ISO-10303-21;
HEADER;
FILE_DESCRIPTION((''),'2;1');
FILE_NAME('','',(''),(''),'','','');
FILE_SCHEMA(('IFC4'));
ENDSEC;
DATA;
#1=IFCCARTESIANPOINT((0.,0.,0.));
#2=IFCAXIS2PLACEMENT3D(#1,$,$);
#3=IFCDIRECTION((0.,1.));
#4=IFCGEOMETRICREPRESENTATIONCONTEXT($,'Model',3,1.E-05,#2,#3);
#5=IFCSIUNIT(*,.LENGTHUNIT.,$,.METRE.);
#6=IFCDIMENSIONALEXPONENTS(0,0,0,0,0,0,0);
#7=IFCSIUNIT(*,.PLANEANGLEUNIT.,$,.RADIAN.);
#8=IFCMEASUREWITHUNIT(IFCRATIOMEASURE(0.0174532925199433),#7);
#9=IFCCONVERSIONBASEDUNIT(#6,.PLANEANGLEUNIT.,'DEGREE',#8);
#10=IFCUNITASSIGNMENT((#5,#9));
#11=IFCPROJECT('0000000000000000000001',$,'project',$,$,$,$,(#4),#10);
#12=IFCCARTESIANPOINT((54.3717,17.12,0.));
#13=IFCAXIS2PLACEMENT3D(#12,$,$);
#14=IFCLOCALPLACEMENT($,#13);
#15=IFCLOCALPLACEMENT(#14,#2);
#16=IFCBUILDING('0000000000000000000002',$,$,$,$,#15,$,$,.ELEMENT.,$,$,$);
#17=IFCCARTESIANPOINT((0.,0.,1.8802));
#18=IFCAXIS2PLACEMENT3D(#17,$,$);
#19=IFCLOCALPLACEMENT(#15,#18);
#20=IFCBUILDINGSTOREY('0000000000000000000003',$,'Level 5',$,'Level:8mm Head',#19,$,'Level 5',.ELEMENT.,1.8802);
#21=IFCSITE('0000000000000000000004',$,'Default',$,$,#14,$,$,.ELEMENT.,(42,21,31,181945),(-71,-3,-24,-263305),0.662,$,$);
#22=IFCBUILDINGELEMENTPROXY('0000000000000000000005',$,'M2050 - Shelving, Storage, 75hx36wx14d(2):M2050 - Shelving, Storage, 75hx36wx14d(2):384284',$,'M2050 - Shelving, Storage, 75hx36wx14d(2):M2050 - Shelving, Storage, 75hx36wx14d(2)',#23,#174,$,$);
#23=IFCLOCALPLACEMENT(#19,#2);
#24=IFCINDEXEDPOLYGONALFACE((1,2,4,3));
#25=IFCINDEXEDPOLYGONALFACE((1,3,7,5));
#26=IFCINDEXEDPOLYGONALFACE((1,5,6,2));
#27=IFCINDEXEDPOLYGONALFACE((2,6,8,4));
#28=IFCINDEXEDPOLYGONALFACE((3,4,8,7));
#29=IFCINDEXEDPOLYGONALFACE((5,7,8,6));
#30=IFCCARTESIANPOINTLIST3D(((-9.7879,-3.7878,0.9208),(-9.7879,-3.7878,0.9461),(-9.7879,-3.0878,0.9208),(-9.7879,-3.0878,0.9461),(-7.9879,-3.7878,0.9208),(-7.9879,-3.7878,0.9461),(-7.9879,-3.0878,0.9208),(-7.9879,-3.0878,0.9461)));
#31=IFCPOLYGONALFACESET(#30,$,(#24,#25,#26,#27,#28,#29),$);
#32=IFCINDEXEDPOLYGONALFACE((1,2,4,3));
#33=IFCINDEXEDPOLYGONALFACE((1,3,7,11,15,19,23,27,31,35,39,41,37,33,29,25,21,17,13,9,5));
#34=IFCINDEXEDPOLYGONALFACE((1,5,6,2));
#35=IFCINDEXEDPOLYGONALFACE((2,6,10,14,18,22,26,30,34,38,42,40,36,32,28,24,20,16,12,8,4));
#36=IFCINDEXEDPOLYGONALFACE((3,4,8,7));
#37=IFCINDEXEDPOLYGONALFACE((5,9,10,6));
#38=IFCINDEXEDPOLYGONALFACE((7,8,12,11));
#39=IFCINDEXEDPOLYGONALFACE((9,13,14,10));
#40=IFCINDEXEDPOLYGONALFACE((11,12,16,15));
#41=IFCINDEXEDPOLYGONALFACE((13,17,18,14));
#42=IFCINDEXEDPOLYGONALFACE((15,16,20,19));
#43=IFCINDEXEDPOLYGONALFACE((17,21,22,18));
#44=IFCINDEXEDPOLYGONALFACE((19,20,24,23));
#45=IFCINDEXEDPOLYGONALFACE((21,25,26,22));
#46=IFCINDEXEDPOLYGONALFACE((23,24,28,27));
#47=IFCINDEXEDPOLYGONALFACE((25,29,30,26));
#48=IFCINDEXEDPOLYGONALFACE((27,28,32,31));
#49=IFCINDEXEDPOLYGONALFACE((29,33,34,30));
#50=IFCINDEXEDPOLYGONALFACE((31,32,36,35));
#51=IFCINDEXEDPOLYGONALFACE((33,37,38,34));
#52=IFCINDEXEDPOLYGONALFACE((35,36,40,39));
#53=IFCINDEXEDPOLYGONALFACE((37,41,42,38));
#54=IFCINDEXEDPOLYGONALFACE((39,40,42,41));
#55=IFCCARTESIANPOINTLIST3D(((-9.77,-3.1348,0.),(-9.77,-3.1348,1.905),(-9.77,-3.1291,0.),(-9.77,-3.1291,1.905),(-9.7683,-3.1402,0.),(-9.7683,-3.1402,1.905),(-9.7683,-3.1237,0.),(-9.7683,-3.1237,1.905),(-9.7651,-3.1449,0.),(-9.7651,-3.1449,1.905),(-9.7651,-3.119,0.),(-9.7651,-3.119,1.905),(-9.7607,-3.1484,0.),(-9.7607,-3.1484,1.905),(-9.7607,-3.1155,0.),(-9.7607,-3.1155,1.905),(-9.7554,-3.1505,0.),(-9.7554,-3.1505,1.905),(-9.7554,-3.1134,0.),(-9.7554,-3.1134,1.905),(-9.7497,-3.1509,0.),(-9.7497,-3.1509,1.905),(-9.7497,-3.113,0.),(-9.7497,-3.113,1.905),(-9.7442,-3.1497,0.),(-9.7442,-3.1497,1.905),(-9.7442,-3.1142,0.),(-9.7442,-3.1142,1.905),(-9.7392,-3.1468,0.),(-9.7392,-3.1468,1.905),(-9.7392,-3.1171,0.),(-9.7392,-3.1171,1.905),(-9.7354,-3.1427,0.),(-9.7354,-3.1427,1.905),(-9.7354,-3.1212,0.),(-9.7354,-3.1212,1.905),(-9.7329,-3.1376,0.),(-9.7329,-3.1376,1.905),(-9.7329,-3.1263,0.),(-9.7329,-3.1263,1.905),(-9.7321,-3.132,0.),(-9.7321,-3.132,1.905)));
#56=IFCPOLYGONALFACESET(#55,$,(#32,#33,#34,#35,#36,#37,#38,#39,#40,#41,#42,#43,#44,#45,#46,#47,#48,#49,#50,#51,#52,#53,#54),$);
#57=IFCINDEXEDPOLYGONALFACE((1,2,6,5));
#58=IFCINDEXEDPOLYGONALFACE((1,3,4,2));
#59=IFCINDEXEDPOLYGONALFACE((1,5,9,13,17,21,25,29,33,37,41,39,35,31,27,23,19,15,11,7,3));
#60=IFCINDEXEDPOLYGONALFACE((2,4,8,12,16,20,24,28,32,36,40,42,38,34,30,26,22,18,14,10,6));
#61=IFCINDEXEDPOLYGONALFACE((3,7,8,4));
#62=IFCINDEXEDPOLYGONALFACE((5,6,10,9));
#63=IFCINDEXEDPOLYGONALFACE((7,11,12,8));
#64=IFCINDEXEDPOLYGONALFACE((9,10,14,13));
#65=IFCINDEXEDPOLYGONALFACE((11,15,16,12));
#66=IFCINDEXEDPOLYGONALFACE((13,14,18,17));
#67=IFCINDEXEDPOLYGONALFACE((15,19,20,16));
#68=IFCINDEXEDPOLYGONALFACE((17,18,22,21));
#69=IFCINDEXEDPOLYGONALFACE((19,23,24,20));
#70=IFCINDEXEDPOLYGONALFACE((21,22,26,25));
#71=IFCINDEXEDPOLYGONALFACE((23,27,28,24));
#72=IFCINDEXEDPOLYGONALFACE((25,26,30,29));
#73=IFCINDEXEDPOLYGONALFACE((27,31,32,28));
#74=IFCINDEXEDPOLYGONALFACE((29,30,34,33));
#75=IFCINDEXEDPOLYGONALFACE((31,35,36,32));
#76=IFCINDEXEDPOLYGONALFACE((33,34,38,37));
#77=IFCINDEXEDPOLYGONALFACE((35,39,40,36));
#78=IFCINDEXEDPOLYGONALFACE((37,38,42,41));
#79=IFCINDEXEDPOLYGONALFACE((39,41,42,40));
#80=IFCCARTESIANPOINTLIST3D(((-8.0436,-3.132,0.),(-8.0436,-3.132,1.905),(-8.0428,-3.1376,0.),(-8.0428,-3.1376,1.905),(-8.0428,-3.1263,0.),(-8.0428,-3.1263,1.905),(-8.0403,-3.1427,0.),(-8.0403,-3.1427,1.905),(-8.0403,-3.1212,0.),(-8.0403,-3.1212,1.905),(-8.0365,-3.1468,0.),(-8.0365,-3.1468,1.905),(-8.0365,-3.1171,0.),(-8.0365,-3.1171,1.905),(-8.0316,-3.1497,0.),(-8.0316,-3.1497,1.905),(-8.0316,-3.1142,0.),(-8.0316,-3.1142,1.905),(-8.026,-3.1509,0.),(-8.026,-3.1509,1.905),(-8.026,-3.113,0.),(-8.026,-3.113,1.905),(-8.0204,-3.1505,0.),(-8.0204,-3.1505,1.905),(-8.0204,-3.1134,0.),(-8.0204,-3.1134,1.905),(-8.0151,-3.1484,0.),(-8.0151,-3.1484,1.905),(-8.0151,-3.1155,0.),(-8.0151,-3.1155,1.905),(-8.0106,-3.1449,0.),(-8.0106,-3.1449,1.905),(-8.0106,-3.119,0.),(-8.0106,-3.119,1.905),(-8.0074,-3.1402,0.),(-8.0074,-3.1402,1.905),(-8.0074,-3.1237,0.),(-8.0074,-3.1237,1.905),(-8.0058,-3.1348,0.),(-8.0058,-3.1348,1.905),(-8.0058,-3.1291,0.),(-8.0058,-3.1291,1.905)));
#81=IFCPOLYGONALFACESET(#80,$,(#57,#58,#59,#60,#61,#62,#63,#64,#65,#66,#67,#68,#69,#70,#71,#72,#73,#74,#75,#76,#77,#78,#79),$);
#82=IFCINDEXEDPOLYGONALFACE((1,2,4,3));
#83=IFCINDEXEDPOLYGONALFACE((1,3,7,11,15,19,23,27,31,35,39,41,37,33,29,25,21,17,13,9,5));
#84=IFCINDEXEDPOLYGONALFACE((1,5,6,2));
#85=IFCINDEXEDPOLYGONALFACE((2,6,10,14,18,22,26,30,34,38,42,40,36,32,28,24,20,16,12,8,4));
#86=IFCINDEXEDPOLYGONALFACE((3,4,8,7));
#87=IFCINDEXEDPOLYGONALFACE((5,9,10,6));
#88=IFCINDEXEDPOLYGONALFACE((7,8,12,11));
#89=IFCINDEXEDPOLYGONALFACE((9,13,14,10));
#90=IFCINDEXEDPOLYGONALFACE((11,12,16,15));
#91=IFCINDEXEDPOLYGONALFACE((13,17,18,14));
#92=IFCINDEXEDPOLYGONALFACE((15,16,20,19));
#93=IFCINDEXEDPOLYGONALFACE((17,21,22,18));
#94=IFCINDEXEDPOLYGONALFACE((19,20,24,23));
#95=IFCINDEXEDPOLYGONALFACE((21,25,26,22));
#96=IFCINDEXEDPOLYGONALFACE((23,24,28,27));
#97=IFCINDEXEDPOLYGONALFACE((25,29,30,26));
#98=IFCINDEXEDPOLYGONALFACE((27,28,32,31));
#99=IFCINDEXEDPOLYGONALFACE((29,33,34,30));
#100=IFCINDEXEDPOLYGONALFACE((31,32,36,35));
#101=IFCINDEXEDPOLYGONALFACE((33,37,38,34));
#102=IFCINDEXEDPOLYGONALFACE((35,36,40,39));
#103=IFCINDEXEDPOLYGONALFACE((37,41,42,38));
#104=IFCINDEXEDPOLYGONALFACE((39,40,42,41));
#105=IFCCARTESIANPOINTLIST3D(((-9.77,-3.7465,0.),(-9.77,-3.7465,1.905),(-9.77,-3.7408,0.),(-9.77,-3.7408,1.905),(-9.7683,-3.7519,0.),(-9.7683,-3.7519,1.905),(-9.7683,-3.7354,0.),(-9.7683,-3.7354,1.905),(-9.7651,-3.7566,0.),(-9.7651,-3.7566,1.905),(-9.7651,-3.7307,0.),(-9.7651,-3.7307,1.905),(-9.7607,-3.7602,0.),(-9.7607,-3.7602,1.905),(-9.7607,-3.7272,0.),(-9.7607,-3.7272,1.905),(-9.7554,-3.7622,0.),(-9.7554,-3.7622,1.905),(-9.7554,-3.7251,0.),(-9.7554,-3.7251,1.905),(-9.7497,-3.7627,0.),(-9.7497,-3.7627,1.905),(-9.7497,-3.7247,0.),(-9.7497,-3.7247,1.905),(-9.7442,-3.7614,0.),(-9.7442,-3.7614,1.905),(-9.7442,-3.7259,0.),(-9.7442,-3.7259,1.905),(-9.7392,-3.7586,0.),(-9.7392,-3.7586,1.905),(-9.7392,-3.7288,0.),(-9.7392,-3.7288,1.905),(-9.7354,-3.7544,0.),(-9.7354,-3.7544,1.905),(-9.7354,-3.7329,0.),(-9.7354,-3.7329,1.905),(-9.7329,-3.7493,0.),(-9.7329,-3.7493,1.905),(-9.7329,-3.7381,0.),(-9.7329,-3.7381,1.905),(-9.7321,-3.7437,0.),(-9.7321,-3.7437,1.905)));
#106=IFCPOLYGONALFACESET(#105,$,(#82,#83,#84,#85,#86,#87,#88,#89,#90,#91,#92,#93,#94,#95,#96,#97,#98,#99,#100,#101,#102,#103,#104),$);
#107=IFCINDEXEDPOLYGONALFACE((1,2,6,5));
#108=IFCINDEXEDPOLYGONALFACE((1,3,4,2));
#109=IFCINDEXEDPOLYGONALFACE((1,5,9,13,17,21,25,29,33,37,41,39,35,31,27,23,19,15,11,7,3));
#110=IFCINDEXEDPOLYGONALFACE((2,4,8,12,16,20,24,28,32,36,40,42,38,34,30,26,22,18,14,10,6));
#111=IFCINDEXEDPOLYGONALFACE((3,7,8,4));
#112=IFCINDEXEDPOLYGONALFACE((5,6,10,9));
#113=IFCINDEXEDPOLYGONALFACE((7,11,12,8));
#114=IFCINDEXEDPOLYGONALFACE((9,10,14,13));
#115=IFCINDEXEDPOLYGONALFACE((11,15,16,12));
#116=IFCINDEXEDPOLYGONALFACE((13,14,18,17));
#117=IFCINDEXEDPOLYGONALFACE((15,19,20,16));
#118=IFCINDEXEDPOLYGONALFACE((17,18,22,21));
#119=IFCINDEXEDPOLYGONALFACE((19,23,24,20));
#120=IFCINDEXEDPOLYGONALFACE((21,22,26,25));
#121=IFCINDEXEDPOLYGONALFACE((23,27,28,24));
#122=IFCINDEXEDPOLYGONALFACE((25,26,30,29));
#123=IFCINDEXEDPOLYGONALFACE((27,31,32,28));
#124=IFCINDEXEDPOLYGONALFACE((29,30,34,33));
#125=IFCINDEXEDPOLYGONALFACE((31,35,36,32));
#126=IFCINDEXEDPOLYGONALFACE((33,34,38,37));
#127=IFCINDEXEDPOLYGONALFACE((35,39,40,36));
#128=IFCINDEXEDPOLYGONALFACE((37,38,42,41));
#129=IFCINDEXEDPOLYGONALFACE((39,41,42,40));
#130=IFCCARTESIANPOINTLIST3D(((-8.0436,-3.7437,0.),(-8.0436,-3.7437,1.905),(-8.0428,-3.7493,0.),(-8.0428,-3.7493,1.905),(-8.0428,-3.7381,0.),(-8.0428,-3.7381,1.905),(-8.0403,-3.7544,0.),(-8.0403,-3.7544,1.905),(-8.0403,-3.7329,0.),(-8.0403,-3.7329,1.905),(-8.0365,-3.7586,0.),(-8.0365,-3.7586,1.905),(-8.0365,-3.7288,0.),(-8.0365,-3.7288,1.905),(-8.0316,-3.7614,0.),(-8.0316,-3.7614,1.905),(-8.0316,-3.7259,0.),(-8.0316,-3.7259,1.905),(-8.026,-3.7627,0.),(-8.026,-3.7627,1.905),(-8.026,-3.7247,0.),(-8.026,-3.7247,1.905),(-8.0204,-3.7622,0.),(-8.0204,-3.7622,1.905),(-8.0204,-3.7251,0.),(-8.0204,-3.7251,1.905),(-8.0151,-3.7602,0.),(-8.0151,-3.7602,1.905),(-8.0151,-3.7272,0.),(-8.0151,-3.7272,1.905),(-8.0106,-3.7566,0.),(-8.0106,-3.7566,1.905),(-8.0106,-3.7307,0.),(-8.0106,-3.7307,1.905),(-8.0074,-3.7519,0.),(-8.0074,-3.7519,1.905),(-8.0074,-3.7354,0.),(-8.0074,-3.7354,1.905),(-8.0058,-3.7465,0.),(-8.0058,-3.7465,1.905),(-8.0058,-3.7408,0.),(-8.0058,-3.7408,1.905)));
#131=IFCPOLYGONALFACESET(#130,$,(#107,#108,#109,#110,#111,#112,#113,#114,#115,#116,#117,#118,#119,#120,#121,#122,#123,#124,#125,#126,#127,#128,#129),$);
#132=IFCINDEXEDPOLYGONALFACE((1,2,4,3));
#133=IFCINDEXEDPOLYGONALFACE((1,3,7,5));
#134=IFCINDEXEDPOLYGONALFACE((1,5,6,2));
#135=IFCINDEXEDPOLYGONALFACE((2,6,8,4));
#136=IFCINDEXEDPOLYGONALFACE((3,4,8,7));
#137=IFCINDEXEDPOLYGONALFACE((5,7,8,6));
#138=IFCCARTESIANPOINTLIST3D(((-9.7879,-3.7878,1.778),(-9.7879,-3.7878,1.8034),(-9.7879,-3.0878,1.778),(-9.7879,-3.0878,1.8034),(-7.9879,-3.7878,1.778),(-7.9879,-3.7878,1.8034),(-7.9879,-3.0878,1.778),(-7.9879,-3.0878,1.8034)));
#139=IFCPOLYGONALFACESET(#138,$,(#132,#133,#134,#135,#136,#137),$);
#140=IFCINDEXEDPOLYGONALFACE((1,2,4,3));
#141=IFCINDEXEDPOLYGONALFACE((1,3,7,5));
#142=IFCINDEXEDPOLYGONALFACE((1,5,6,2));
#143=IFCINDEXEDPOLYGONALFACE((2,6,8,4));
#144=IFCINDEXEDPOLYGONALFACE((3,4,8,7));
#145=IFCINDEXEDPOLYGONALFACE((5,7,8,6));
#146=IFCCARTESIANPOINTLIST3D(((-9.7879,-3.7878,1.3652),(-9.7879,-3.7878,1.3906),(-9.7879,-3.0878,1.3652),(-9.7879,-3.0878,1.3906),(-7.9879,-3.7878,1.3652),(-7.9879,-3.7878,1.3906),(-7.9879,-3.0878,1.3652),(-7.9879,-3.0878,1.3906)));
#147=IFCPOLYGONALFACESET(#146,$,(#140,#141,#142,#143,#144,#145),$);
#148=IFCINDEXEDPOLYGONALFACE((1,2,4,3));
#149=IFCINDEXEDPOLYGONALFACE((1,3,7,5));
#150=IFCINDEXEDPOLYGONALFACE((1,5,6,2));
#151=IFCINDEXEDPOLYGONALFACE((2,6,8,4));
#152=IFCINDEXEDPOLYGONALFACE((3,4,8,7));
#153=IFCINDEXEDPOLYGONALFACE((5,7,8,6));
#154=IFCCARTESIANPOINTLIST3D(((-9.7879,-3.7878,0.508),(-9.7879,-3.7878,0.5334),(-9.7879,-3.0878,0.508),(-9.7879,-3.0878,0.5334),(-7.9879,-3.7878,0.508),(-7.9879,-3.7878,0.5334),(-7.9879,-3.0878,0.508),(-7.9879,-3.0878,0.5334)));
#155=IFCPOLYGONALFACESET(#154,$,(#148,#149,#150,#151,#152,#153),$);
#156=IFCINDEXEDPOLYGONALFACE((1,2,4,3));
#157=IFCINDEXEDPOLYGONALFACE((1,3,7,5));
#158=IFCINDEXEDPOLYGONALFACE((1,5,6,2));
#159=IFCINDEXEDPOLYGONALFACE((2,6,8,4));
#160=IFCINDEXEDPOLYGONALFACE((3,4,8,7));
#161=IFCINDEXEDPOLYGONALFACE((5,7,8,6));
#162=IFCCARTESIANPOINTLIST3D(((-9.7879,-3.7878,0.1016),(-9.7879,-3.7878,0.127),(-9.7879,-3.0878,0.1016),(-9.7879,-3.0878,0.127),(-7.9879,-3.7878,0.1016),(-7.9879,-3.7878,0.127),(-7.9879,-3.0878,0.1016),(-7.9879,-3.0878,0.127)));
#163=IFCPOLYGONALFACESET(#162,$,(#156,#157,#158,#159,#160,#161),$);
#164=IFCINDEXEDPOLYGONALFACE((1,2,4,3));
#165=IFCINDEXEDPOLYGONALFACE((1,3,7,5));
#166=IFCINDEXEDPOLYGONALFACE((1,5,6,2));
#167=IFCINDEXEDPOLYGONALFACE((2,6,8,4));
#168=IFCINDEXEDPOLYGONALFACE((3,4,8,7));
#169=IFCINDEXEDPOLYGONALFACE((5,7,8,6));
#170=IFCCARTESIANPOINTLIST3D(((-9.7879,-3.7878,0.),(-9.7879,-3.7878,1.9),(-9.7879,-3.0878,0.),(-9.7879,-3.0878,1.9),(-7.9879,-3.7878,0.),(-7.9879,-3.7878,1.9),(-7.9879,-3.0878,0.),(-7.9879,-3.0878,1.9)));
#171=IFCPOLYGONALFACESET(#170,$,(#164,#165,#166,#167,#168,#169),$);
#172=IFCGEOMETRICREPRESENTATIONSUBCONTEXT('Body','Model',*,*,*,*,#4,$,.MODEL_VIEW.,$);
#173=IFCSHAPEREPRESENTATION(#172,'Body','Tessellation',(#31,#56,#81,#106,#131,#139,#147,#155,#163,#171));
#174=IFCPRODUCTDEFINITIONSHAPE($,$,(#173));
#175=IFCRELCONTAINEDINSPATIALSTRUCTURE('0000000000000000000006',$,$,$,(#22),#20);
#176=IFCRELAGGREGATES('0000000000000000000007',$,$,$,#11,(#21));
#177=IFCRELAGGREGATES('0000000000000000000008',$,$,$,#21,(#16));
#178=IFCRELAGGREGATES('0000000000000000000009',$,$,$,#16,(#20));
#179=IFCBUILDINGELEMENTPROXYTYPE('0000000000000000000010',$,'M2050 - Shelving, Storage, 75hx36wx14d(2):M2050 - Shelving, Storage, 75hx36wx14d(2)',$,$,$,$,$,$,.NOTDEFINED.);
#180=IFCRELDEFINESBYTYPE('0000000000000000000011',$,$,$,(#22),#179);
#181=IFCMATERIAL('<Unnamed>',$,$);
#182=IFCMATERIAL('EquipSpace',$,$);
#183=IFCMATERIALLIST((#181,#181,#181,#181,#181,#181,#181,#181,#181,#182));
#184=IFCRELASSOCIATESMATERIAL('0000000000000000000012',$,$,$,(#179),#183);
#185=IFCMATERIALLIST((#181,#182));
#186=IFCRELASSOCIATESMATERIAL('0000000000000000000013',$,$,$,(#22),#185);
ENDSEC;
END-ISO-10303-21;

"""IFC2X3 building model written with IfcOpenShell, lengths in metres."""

from ifc_helpers import new_model, entity, si_unit, converted_unit, direction, frame, frame_2d, origin, origin_2d_with_axis, place, context, subcontext, project, spatial, rectangle, circle, extrude, source, transform, mapped, material, material_list, type_object, type_shapes, element, save


model = new_model("IFC2X3")

# Units and contexts
model_context = context("Model", 3, precision=1e-05, world=origin(), true_north=direction((0.0, 1.0)))
body_context = subcontext(model_context, "Body", "Model", "MODEL_VIEW")
ifc_project = project(units=[si_unit("LENGTHUNIT", "METRE"), converted_unit("PLANEANGLEUNIT", "DEGREE", entity("IfcRatioMeasure", 0.0174532925199433), si_unit("PLANEANGLEUNIT", "RADIAN"), dimensions=[0, 0, 0, 0, 0, 0, 0])], contexts=[model_context])

# Site, building, storey
site_placement = place(None, frame((54.3717, 17.12, 0.0)))
site = spatial("IfcSite", under=ifc_project, at=site_placement, Name="Default", CompositionType="ELEMENT", RefLatitude=(42, 21, 31, 181945), RefLongitude=(-71, -3, -24, -263305), RefElevation=0.662)
building_placement = place(site_placement, origin())
building = spatial("IfcBuilding", under=site, at=building_placement, CompositionType="ELEMENT")
storey_placement = place(building_placement, frame((0.0, 0.0, 1.8802)))
storey = spatial("IfcBuildingStorey", under=building, at=storey_placement, Name="Level 5", ObjectType="Level:8mm Head", LongName="Level 5", CompositionType="ELEMENT", Elevation=1.8802)

# Building element proxy
ifc_material_1 = material(Name="<Unnamed>")
ifc_material_2 = material(Name="EquipSpace")
ifc_material_list_1 = material_list([ifc_material_1, ifc_material_1, ifc_material_1, ifc_material_1, ifc_material_1, ifc_material_1, ifc_material_1, ifc_material_1, ifc_material_1, ifc_material_2])
building_element_proxy_type = type_object("IfcBuildingElementProxyType", Name="M2050 - Shelving, Storage, 75hx36wx14d(2):M2050 - Shelving, Storage, 75hx36wx14d(2)", PredefinedType="NOTDEFINED", material=ifc_material_list_1)
shared_shape = source(origin(), body_context, "Body", "SweptSolid", [
    extrude(rectangle(XDim=1.8, YDim=0.7, at=origin_2d_with_axis()), frame((0.0, 0.0, 0.9207), z_axis=(0.0, 0.0, 1.0), x_axis=(-1.0, 0.0, 0.0)), (0.0, 0.0, 1.0), 0.0254),
    extrude(circle(Radius=0.0191, at=origin_2d_with_axis()), frame((0.8633, -0.3059, 0.0), z_axis=(0.0, 0.0, 1.0), x_axis=(-1.0, 0.0, 0.0)), (0.0, 0.0, 1.0), 1.905),
    extrude(circle(Radius=0.0191, at=origin_2d_with_axis()), frame((-0.8633, -0.3059, 0.0)), (0.0, 0.0, 1.0), 1.905),
    extrude(circle(Radius=0.0191, at=origin_2d_with_axis()), frame((0.8633, 0.3059, 0.0), z_axis=(0.0, 0.0, 1.0), x_axis=(-1.0, 0.0, 0.0)), (0.0, 0.0, 1.0), 1.905),
    extrude(circle(Radius=0.0191, at=origin_2d_with_axis()), frame((-0.8633, 0.3059, 0.0)), (0.0, 0.0, 1.0), 1.905),
    extrude(rectangle(XDim=1.8, YDim=0.7, at=origin_2d_with_axis()), frame((0.0, 0.0, 1.778), z_axis=(0.0, 0.0, 1.0), x_axis=(-1.0, 0.0, 0.0)), (0.0, 0.0, 1.0), 0.0254),
    extrude(rectangle(XDim=1.8, YDim=0.7, at=origin_2d_with_axis()), frame((0.0, 0.0, 1.3653), z_axis=(0.0, 0.0, 1.0), x_axis=(-1.0, 0.0, 0.0)), (0.0, 0.0, 1.0), 0.0254),
    extrude(rectangle(XDim=1.8, YDim=0.7, at=origin_2d_with_axis()), frame((0.0, 0.0, 0.508), z_axis=(0.0, 0.0, 1.0), x_axis=(-1.0, 0.0, 0.0)), (0.0, 0.0, 1.0), 0.0254),
    extrude(rectangle(XDim=1.8, YDim=0.7, at=origin_2d_with_axis()), frame((0.0, 0.0, 0.1016), z_axis=(0.0, 0.0, 1.0), x_axis=(-1.0, 0.0, 0.0)), (0.0, 0.0, 1.0), 0.0254),
    extrude(rectangle(XDim=0.7, YDim=1.8, at=frame_2d((0.0, 0.18), x_axis=(1.0, 0.0))), frame((-0.18, 0.0, 0.0), z_axis=(0.0, 0.0, 1.0), x_axis=(0.0, -1.0, 0.0)), (0.0, 0.0, 1.0), 1.9),
])
type_shapes(building_element_proxy_type, [shared_shape])
ifc_material_list_2 = material_list([ifc_material_1, ifc_material_2])
proxy_1_placement = place(storey_placement, frame((-8.8879, -3.4378, 0.0), z_axis=(0.0, 0.0, 1.0), x_axis=(-1.0, 0.0, 0.0)))
element("IfcBuildingElementProxy", 1, at=proxy_1_placement, inside=storey, type_object=building_element_proxy_type, material=ifc_material_list_2, Name="M2050 - Shelving, Storage, 75hx36wx14d(2):M2050 - Shelving, Storage, 75hx36wx14d(2):384284", ObjectType="M2050 - Shelving, Storage, 75hx36wx14d(2):M2050 - Shelving, Storage, 75hx36wx14d(2)", context=body_context, shape_type="MappedRepresentation", body=[
    mapped(shared_shape, transform((0.0, 0.0, 0.0), scale=1.0)),
])

save(model, "model.ifc")
